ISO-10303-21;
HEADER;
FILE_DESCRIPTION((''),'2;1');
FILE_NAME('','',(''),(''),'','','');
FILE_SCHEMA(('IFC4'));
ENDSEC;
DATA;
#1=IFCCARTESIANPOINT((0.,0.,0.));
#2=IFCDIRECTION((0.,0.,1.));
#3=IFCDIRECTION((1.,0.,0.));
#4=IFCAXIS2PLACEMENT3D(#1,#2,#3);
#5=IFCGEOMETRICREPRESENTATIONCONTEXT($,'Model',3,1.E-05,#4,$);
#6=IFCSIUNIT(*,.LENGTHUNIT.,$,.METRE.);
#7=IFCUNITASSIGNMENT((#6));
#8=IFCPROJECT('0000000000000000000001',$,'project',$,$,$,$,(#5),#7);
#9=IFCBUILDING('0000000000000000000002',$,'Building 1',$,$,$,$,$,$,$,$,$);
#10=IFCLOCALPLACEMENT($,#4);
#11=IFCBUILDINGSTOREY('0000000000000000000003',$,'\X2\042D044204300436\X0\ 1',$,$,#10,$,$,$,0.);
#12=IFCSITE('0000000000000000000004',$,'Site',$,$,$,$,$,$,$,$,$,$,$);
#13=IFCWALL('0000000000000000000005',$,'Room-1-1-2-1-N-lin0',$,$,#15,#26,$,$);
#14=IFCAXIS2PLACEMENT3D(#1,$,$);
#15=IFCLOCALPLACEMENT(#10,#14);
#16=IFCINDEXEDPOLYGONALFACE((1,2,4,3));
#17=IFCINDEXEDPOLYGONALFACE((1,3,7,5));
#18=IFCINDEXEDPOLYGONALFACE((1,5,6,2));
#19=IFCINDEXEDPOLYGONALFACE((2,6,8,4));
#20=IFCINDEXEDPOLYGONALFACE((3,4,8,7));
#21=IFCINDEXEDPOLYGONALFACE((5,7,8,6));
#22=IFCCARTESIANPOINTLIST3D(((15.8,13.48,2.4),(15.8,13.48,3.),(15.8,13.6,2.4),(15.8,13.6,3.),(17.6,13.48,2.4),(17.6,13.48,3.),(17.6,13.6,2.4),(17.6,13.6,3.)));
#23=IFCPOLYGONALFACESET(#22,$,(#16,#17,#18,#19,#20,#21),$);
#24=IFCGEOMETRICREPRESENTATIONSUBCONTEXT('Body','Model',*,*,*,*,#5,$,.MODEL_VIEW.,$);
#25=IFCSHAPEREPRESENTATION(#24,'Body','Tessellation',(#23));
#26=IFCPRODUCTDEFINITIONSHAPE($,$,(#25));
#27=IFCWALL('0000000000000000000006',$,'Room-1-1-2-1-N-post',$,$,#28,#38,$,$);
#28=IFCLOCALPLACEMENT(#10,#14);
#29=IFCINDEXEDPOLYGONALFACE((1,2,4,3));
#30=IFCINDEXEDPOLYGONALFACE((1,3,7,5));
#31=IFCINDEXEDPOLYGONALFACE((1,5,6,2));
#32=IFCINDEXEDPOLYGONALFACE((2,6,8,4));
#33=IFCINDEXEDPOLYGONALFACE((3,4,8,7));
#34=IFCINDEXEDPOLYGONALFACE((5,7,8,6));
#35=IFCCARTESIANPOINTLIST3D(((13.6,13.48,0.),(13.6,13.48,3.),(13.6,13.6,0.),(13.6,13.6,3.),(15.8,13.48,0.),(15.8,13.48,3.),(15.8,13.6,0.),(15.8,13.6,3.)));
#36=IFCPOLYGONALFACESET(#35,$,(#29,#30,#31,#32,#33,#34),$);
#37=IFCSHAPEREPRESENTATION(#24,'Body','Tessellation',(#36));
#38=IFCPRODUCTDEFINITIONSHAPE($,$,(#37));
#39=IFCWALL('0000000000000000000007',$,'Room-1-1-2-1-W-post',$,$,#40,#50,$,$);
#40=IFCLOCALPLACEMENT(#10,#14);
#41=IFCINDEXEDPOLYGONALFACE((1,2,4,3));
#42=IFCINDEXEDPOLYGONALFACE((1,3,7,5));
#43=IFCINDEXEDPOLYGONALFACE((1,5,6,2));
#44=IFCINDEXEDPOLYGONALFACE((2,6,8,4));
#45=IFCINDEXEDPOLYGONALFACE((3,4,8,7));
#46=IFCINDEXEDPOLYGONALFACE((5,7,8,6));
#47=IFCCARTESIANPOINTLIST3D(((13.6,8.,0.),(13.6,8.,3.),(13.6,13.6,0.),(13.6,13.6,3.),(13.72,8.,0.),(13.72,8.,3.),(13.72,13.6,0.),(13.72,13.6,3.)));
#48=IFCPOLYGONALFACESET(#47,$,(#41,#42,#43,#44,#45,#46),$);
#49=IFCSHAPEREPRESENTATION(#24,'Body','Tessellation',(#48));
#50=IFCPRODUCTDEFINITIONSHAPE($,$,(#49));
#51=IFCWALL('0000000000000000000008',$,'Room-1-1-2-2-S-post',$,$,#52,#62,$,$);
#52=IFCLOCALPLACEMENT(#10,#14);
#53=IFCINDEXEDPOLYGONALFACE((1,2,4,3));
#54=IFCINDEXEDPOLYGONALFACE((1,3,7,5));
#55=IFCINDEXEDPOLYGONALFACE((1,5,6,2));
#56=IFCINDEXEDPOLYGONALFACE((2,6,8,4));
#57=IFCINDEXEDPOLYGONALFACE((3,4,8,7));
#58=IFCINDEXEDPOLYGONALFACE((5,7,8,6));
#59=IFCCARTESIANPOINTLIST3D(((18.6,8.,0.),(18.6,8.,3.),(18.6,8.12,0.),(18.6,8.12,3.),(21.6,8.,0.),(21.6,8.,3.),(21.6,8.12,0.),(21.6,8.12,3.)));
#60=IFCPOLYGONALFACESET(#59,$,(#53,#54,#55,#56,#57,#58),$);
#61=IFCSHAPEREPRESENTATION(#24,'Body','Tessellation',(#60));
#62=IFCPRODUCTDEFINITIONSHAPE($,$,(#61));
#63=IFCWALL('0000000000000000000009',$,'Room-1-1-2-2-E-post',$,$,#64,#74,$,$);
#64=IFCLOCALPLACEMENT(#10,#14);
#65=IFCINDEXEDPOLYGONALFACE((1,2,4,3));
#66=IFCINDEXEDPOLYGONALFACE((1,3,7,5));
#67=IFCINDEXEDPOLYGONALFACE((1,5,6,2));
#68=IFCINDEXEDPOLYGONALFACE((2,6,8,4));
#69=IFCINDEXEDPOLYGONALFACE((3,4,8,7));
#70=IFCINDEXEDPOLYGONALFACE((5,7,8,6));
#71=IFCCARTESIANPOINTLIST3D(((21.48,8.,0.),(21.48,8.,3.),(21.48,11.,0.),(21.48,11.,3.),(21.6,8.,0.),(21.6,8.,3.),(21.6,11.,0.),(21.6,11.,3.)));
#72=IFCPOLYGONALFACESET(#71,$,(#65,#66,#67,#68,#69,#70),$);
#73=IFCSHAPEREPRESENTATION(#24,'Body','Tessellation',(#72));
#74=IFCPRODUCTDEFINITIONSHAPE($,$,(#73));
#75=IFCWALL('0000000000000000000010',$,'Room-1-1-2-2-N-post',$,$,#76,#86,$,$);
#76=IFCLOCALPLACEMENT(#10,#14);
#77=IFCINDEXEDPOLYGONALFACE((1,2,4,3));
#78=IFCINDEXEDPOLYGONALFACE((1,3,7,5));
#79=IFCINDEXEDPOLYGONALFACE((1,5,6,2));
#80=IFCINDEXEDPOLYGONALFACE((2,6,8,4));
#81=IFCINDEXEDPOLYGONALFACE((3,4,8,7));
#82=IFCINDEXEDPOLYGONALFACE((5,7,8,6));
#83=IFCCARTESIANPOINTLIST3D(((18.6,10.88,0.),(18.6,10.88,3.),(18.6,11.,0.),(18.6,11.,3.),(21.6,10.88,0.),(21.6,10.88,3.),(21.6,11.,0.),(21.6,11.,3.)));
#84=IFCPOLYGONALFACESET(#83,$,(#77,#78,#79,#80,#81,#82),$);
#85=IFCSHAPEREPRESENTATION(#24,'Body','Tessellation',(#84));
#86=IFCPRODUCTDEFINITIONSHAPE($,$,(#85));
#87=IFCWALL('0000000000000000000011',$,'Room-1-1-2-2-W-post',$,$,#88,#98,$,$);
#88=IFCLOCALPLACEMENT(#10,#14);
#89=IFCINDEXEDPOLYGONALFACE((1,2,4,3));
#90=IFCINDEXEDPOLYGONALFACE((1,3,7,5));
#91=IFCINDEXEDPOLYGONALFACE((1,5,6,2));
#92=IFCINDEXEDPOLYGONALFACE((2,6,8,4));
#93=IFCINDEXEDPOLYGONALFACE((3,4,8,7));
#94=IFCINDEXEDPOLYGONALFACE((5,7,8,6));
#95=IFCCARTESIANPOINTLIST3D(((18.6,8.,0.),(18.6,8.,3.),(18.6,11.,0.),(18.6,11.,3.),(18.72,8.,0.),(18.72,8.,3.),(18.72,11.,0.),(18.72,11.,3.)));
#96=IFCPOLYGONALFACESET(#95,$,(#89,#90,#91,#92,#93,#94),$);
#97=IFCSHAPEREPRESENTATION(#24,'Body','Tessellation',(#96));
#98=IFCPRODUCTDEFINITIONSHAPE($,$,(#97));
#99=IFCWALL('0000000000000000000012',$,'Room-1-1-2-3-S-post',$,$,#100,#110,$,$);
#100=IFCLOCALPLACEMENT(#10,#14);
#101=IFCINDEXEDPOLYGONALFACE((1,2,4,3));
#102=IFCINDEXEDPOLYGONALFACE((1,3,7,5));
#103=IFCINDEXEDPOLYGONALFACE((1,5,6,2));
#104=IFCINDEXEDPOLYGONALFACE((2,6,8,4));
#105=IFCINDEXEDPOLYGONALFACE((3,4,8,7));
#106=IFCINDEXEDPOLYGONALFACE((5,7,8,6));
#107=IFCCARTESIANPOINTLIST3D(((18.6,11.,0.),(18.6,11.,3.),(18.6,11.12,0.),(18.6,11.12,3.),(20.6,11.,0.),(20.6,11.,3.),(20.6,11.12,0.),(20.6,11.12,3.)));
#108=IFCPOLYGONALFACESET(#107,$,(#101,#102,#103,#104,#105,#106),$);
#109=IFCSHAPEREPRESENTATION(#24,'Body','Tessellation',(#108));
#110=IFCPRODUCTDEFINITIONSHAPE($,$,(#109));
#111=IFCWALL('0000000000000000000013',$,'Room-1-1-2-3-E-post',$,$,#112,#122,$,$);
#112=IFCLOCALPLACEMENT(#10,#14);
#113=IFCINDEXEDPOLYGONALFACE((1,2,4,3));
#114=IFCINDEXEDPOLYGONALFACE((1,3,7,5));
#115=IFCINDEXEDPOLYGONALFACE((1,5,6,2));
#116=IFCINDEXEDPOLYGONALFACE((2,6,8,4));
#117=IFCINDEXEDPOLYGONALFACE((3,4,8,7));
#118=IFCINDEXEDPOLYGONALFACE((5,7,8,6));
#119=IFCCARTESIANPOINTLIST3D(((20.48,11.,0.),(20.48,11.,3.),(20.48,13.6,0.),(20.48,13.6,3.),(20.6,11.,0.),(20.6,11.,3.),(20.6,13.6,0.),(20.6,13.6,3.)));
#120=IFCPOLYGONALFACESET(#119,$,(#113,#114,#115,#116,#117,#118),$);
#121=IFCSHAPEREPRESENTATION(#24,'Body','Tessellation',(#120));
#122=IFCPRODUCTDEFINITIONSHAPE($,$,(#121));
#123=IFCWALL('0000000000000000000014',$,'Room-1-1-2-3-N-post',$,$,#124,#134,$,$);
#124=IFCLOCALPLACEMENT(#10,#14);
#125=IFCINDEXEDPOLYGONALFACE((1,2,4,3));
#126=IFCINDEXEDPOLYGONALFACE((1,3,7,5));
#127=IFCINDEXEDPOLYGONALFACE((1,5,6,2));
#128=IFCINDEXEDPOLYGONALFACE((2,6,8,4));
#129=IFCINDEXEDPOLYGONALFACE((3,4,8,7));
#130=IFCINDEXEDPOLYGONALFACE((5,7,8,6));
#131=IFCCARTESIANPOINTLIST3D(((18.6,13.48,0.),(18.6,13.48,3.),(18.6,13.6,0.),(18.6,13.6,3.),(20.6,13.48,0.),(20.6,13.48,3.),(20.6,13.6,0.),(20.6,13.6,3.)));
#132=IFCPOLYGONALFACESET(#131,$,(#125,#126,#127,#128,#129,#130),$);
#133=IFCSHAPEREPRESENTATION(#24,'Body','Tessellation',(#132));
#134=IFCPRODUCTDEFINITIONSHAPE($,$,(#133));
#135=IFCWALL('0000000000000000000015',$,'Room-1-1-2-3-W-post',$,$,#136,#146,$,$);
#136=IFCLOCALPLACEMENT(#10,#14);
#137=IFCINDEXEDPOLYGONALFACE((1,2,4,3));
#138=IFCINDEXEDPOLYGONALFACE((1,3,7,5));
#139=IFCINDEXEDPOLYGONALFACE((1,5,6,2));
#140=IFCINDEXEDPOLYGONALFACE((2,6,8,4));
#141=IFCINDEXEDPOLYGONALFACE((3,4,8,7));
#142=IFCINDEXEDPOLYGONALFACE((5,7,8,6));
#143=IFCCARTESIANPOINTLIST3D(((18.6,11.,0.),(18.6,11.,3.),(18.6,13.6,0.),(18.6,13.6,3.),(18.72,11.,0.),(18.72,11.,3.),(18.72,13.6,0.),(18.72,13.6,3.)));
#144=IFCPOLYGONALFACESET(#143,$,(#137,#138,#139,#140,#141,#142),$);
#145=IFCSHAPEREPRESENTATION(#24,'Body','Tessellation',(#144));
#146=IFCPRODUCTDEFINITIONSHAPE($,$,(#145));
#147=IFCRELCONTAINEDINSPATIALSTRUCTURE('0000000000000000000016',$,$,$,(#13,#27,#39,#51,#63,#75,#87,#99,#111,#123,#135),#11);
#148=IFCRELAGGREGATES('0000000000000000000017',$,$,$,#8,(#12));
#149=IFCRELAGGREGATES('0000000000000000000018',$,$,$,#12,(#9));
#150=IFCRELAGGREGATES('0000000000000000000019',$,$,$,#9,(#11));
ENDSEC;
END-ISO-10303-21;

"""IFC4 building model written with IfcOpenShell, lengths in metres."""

from ifc_helpers import new_model, si_unit, frame, origin_with_axes, place, context, subcontext, project, spatial, indexed_curve, outline, extrude, element, save


model = new_model("IFC4")

# Units and contexts
model_context = context("Model", 3, precision=1e-05, world=origin_with_axes())
body_context = subcontext(model_context, "Body", "Model", "MODEL_VIEW")
ifc_project = project(units=[si_unit("LENGTHUNIT", "METRE")], contexts=[model_context])

# Site, building, storey
site = spatial("IfcSite", under=ifc_project, Name="Site")
building = spatial("IfcBuilding", under=site, Name="Building 1")
storey_placement = place(None, origin_with_axes())
storey = spatial("IfcBuildingStorey", under=building, at=storey_placement, Name="Этаж 1", Elevation=0.0)

# Walls
wall_1_placement = place(storey_placement, frame((17.6, 13.6, 2.4), z_axis=(0.0, 0.0, 1.0), x_axis=(-1.0, 0.0, 0.0)))
element("IfcWall", 1, at=wall_1_placement, inside=storey, Name="Room-1-1-2-1-N-lin0", context=body_context, shape_type="SweptSolid", body=[
    extrude(outline(indexed_curve([(0.0, 0.0), (0.0, 0.12), (1.8, 0.12), (1.8, 0.0), (0.0, 0.0)], self_intersect=False)), origin_with_axes(), (0.0, 0.0, 1.0), 0.6),
])
wall_2_placement = place(storey_placement, frame((15.8, 13.6, 0.0), z_axis=(0.0, 0.0, 1.0), x_axis=(-1.0, 0.0, 0.0)))
element("IfcWall", 2, at=wall_2_placement, inside=storey, Name="Room-1-1-2-1-N-post", context=body_context, shape_type="SweptSolid", body=[
    extrude(outline(indexed_curve([(0.0, 0.0), (0.0, 0.12), (2.2, 0.12), (2.2, 0.0), (0.0, 0.0)], self_intersect=False)), origin_with_axes(), (0.0, 0.0, 1.0), 3.0),
])
wall_3_placement = place(storey_placement, frame((13.6, 13.6, 0.0), z_axis=(0.0, 0.0, 1.0), x_axis=(0.0, -1.0, 0.0)))
element("IfcWall", 3, at=wall_3_placement, inside=storey, Name="Room-1-1-2-1-W-post", context=body_context, shape_type="SweptSolid", body=[
    extrude(outline(indexed_curve([(0.0, 0.0), (0.0, 0.12), (5.6, 0.12), (5.6, 0.0), (0.0, 0.0)], self_intersect=False)), origin_with_axes(), (0.0, 0.0, 1.0), 3.0),
])
for number, where, z_axis, x_axis, name in (
    (4, (18.6, 8.0, 0.0), (0.0, 0.0, 1.0), (1.0, 0.0, 0.0), "Room-1-1-2-2-S-post"),
    (5, (21.6, 8.0, 0.0), (0.0, 0.0, 1.0), (0.0, 1.0, 0.0), "Room-1-1-2-2-E-post"),
    (6, (21.6, 11.0, 0.0), (0.0, 0.0, 1.0), (-1.0, 0.0, 0.0), "Room-1-1-2-2-N-post"),
    (7, (18.6, 11.0, 0.0), (0.0, 0.0, 1.0), (0.0, -1.0, 0.0), "Room-1-1-2-2-W-post"),
):
    element("IfcWall", number, at=place(storey_placement, frame(where, z_axis=z_axis, x_axis=x_axis)), inside=storey, Name=name, context=body_context, shape_type="SweptSolid", body=[
        extrude(outline(indexed_curve([(0.0, 0.0), (0.0, 0.12), (3.0, 0.12), (3.0, 0.0), (0.0, 0.0)], self_intersect=False)), origin_with_axes(), (0.0, 0.0, 1.0), 3.0),
    ])
wall_4_placement = place(storey_placement, frame((18.6, 11.0, 0.0), z_axis=(0.0, 0.0, 1.0), x_axis=(1.0, 0.0, 0.0)))
element("IfcWall", 8, at=wall_4_placement, inside=storey, Name="Room-1-1-2-3-S-post", context=body_context, shape_type="SweptSolid", body=[
    extrude(outline(indexed_curve([(0.0, 0.0), (0.0, 0.12), (2.0, 0.12), (2.0, 0.0), (0.0, 0.0)], self_intersect=False)), origin_with_axes(), (0.0, 0.0, 1.0), 3.0),
])
wall_5_placement = place(storey_placement, frame((20.6, 11.0, 0.0), z_axis=(0.0, 0.0, 1.0), x_axis=(0.0, 1.0, 0.0)))
element("IfcWall", 9, at=wall_5_placement, inside=storey, Name="Room-1-1-2-3-E-post", context=body_context, shape_type="SweptSolid", body=[
    extrude(outline(indexed_curve([(0.0, 0.0), (0.0, 0.12), (2.6, 0.12), (2.6, 0.0), (0.0, 0.0)], self_intersect=False)), origin_with_axes(), (0.0, 0.0, 1.0), 3.0),
])
wall_6_placement = place(storey_placement, frame((20.6, 13.6, 0.0), z_axis=(0.0, 0.0, 1.0), x_axis=(-1.0, 0.0, 0.0)))
element("IfcWall", 10, at=wall_6_placement, inside=storey, Name="Room-1-1-2-3-N-post", context=body_context, shape_type="SweptSolid", body=[
    extrude(outline(indexed_curve([(0.0, 0.0), (0.0, 0.12), (2.0, 0.12), (2.0, 0.0), (0.0, 0.0)], self_intersect=False)), origin_with_axes(), (0.0, 0.0, 1.0), 3.0),
])
wall_7_placement = place(storey_placement, frame((18.6, 13.6, 0.0), z_axis=(0.0, 0.0, 1.0), x_axis=(0.0, -1.0, 0.0)))
element("IfcWall", 11, at=wall_7_placement, inside=storey, Name="Room-1-1-2-3-W-post", context=body_context, shape_type="SweptSolid", body=[
    extrude(outline(indexed_curve([(0.0, 0.0), (0.0, 0.12), (2.6, 0.12), (2.6, 0.0), (0.0, 0.0)], self_intersect=False)), origin_with_axes(), (0.0, 0.0, 1.0), 3.0),
])

save(model, "model.ifc")
